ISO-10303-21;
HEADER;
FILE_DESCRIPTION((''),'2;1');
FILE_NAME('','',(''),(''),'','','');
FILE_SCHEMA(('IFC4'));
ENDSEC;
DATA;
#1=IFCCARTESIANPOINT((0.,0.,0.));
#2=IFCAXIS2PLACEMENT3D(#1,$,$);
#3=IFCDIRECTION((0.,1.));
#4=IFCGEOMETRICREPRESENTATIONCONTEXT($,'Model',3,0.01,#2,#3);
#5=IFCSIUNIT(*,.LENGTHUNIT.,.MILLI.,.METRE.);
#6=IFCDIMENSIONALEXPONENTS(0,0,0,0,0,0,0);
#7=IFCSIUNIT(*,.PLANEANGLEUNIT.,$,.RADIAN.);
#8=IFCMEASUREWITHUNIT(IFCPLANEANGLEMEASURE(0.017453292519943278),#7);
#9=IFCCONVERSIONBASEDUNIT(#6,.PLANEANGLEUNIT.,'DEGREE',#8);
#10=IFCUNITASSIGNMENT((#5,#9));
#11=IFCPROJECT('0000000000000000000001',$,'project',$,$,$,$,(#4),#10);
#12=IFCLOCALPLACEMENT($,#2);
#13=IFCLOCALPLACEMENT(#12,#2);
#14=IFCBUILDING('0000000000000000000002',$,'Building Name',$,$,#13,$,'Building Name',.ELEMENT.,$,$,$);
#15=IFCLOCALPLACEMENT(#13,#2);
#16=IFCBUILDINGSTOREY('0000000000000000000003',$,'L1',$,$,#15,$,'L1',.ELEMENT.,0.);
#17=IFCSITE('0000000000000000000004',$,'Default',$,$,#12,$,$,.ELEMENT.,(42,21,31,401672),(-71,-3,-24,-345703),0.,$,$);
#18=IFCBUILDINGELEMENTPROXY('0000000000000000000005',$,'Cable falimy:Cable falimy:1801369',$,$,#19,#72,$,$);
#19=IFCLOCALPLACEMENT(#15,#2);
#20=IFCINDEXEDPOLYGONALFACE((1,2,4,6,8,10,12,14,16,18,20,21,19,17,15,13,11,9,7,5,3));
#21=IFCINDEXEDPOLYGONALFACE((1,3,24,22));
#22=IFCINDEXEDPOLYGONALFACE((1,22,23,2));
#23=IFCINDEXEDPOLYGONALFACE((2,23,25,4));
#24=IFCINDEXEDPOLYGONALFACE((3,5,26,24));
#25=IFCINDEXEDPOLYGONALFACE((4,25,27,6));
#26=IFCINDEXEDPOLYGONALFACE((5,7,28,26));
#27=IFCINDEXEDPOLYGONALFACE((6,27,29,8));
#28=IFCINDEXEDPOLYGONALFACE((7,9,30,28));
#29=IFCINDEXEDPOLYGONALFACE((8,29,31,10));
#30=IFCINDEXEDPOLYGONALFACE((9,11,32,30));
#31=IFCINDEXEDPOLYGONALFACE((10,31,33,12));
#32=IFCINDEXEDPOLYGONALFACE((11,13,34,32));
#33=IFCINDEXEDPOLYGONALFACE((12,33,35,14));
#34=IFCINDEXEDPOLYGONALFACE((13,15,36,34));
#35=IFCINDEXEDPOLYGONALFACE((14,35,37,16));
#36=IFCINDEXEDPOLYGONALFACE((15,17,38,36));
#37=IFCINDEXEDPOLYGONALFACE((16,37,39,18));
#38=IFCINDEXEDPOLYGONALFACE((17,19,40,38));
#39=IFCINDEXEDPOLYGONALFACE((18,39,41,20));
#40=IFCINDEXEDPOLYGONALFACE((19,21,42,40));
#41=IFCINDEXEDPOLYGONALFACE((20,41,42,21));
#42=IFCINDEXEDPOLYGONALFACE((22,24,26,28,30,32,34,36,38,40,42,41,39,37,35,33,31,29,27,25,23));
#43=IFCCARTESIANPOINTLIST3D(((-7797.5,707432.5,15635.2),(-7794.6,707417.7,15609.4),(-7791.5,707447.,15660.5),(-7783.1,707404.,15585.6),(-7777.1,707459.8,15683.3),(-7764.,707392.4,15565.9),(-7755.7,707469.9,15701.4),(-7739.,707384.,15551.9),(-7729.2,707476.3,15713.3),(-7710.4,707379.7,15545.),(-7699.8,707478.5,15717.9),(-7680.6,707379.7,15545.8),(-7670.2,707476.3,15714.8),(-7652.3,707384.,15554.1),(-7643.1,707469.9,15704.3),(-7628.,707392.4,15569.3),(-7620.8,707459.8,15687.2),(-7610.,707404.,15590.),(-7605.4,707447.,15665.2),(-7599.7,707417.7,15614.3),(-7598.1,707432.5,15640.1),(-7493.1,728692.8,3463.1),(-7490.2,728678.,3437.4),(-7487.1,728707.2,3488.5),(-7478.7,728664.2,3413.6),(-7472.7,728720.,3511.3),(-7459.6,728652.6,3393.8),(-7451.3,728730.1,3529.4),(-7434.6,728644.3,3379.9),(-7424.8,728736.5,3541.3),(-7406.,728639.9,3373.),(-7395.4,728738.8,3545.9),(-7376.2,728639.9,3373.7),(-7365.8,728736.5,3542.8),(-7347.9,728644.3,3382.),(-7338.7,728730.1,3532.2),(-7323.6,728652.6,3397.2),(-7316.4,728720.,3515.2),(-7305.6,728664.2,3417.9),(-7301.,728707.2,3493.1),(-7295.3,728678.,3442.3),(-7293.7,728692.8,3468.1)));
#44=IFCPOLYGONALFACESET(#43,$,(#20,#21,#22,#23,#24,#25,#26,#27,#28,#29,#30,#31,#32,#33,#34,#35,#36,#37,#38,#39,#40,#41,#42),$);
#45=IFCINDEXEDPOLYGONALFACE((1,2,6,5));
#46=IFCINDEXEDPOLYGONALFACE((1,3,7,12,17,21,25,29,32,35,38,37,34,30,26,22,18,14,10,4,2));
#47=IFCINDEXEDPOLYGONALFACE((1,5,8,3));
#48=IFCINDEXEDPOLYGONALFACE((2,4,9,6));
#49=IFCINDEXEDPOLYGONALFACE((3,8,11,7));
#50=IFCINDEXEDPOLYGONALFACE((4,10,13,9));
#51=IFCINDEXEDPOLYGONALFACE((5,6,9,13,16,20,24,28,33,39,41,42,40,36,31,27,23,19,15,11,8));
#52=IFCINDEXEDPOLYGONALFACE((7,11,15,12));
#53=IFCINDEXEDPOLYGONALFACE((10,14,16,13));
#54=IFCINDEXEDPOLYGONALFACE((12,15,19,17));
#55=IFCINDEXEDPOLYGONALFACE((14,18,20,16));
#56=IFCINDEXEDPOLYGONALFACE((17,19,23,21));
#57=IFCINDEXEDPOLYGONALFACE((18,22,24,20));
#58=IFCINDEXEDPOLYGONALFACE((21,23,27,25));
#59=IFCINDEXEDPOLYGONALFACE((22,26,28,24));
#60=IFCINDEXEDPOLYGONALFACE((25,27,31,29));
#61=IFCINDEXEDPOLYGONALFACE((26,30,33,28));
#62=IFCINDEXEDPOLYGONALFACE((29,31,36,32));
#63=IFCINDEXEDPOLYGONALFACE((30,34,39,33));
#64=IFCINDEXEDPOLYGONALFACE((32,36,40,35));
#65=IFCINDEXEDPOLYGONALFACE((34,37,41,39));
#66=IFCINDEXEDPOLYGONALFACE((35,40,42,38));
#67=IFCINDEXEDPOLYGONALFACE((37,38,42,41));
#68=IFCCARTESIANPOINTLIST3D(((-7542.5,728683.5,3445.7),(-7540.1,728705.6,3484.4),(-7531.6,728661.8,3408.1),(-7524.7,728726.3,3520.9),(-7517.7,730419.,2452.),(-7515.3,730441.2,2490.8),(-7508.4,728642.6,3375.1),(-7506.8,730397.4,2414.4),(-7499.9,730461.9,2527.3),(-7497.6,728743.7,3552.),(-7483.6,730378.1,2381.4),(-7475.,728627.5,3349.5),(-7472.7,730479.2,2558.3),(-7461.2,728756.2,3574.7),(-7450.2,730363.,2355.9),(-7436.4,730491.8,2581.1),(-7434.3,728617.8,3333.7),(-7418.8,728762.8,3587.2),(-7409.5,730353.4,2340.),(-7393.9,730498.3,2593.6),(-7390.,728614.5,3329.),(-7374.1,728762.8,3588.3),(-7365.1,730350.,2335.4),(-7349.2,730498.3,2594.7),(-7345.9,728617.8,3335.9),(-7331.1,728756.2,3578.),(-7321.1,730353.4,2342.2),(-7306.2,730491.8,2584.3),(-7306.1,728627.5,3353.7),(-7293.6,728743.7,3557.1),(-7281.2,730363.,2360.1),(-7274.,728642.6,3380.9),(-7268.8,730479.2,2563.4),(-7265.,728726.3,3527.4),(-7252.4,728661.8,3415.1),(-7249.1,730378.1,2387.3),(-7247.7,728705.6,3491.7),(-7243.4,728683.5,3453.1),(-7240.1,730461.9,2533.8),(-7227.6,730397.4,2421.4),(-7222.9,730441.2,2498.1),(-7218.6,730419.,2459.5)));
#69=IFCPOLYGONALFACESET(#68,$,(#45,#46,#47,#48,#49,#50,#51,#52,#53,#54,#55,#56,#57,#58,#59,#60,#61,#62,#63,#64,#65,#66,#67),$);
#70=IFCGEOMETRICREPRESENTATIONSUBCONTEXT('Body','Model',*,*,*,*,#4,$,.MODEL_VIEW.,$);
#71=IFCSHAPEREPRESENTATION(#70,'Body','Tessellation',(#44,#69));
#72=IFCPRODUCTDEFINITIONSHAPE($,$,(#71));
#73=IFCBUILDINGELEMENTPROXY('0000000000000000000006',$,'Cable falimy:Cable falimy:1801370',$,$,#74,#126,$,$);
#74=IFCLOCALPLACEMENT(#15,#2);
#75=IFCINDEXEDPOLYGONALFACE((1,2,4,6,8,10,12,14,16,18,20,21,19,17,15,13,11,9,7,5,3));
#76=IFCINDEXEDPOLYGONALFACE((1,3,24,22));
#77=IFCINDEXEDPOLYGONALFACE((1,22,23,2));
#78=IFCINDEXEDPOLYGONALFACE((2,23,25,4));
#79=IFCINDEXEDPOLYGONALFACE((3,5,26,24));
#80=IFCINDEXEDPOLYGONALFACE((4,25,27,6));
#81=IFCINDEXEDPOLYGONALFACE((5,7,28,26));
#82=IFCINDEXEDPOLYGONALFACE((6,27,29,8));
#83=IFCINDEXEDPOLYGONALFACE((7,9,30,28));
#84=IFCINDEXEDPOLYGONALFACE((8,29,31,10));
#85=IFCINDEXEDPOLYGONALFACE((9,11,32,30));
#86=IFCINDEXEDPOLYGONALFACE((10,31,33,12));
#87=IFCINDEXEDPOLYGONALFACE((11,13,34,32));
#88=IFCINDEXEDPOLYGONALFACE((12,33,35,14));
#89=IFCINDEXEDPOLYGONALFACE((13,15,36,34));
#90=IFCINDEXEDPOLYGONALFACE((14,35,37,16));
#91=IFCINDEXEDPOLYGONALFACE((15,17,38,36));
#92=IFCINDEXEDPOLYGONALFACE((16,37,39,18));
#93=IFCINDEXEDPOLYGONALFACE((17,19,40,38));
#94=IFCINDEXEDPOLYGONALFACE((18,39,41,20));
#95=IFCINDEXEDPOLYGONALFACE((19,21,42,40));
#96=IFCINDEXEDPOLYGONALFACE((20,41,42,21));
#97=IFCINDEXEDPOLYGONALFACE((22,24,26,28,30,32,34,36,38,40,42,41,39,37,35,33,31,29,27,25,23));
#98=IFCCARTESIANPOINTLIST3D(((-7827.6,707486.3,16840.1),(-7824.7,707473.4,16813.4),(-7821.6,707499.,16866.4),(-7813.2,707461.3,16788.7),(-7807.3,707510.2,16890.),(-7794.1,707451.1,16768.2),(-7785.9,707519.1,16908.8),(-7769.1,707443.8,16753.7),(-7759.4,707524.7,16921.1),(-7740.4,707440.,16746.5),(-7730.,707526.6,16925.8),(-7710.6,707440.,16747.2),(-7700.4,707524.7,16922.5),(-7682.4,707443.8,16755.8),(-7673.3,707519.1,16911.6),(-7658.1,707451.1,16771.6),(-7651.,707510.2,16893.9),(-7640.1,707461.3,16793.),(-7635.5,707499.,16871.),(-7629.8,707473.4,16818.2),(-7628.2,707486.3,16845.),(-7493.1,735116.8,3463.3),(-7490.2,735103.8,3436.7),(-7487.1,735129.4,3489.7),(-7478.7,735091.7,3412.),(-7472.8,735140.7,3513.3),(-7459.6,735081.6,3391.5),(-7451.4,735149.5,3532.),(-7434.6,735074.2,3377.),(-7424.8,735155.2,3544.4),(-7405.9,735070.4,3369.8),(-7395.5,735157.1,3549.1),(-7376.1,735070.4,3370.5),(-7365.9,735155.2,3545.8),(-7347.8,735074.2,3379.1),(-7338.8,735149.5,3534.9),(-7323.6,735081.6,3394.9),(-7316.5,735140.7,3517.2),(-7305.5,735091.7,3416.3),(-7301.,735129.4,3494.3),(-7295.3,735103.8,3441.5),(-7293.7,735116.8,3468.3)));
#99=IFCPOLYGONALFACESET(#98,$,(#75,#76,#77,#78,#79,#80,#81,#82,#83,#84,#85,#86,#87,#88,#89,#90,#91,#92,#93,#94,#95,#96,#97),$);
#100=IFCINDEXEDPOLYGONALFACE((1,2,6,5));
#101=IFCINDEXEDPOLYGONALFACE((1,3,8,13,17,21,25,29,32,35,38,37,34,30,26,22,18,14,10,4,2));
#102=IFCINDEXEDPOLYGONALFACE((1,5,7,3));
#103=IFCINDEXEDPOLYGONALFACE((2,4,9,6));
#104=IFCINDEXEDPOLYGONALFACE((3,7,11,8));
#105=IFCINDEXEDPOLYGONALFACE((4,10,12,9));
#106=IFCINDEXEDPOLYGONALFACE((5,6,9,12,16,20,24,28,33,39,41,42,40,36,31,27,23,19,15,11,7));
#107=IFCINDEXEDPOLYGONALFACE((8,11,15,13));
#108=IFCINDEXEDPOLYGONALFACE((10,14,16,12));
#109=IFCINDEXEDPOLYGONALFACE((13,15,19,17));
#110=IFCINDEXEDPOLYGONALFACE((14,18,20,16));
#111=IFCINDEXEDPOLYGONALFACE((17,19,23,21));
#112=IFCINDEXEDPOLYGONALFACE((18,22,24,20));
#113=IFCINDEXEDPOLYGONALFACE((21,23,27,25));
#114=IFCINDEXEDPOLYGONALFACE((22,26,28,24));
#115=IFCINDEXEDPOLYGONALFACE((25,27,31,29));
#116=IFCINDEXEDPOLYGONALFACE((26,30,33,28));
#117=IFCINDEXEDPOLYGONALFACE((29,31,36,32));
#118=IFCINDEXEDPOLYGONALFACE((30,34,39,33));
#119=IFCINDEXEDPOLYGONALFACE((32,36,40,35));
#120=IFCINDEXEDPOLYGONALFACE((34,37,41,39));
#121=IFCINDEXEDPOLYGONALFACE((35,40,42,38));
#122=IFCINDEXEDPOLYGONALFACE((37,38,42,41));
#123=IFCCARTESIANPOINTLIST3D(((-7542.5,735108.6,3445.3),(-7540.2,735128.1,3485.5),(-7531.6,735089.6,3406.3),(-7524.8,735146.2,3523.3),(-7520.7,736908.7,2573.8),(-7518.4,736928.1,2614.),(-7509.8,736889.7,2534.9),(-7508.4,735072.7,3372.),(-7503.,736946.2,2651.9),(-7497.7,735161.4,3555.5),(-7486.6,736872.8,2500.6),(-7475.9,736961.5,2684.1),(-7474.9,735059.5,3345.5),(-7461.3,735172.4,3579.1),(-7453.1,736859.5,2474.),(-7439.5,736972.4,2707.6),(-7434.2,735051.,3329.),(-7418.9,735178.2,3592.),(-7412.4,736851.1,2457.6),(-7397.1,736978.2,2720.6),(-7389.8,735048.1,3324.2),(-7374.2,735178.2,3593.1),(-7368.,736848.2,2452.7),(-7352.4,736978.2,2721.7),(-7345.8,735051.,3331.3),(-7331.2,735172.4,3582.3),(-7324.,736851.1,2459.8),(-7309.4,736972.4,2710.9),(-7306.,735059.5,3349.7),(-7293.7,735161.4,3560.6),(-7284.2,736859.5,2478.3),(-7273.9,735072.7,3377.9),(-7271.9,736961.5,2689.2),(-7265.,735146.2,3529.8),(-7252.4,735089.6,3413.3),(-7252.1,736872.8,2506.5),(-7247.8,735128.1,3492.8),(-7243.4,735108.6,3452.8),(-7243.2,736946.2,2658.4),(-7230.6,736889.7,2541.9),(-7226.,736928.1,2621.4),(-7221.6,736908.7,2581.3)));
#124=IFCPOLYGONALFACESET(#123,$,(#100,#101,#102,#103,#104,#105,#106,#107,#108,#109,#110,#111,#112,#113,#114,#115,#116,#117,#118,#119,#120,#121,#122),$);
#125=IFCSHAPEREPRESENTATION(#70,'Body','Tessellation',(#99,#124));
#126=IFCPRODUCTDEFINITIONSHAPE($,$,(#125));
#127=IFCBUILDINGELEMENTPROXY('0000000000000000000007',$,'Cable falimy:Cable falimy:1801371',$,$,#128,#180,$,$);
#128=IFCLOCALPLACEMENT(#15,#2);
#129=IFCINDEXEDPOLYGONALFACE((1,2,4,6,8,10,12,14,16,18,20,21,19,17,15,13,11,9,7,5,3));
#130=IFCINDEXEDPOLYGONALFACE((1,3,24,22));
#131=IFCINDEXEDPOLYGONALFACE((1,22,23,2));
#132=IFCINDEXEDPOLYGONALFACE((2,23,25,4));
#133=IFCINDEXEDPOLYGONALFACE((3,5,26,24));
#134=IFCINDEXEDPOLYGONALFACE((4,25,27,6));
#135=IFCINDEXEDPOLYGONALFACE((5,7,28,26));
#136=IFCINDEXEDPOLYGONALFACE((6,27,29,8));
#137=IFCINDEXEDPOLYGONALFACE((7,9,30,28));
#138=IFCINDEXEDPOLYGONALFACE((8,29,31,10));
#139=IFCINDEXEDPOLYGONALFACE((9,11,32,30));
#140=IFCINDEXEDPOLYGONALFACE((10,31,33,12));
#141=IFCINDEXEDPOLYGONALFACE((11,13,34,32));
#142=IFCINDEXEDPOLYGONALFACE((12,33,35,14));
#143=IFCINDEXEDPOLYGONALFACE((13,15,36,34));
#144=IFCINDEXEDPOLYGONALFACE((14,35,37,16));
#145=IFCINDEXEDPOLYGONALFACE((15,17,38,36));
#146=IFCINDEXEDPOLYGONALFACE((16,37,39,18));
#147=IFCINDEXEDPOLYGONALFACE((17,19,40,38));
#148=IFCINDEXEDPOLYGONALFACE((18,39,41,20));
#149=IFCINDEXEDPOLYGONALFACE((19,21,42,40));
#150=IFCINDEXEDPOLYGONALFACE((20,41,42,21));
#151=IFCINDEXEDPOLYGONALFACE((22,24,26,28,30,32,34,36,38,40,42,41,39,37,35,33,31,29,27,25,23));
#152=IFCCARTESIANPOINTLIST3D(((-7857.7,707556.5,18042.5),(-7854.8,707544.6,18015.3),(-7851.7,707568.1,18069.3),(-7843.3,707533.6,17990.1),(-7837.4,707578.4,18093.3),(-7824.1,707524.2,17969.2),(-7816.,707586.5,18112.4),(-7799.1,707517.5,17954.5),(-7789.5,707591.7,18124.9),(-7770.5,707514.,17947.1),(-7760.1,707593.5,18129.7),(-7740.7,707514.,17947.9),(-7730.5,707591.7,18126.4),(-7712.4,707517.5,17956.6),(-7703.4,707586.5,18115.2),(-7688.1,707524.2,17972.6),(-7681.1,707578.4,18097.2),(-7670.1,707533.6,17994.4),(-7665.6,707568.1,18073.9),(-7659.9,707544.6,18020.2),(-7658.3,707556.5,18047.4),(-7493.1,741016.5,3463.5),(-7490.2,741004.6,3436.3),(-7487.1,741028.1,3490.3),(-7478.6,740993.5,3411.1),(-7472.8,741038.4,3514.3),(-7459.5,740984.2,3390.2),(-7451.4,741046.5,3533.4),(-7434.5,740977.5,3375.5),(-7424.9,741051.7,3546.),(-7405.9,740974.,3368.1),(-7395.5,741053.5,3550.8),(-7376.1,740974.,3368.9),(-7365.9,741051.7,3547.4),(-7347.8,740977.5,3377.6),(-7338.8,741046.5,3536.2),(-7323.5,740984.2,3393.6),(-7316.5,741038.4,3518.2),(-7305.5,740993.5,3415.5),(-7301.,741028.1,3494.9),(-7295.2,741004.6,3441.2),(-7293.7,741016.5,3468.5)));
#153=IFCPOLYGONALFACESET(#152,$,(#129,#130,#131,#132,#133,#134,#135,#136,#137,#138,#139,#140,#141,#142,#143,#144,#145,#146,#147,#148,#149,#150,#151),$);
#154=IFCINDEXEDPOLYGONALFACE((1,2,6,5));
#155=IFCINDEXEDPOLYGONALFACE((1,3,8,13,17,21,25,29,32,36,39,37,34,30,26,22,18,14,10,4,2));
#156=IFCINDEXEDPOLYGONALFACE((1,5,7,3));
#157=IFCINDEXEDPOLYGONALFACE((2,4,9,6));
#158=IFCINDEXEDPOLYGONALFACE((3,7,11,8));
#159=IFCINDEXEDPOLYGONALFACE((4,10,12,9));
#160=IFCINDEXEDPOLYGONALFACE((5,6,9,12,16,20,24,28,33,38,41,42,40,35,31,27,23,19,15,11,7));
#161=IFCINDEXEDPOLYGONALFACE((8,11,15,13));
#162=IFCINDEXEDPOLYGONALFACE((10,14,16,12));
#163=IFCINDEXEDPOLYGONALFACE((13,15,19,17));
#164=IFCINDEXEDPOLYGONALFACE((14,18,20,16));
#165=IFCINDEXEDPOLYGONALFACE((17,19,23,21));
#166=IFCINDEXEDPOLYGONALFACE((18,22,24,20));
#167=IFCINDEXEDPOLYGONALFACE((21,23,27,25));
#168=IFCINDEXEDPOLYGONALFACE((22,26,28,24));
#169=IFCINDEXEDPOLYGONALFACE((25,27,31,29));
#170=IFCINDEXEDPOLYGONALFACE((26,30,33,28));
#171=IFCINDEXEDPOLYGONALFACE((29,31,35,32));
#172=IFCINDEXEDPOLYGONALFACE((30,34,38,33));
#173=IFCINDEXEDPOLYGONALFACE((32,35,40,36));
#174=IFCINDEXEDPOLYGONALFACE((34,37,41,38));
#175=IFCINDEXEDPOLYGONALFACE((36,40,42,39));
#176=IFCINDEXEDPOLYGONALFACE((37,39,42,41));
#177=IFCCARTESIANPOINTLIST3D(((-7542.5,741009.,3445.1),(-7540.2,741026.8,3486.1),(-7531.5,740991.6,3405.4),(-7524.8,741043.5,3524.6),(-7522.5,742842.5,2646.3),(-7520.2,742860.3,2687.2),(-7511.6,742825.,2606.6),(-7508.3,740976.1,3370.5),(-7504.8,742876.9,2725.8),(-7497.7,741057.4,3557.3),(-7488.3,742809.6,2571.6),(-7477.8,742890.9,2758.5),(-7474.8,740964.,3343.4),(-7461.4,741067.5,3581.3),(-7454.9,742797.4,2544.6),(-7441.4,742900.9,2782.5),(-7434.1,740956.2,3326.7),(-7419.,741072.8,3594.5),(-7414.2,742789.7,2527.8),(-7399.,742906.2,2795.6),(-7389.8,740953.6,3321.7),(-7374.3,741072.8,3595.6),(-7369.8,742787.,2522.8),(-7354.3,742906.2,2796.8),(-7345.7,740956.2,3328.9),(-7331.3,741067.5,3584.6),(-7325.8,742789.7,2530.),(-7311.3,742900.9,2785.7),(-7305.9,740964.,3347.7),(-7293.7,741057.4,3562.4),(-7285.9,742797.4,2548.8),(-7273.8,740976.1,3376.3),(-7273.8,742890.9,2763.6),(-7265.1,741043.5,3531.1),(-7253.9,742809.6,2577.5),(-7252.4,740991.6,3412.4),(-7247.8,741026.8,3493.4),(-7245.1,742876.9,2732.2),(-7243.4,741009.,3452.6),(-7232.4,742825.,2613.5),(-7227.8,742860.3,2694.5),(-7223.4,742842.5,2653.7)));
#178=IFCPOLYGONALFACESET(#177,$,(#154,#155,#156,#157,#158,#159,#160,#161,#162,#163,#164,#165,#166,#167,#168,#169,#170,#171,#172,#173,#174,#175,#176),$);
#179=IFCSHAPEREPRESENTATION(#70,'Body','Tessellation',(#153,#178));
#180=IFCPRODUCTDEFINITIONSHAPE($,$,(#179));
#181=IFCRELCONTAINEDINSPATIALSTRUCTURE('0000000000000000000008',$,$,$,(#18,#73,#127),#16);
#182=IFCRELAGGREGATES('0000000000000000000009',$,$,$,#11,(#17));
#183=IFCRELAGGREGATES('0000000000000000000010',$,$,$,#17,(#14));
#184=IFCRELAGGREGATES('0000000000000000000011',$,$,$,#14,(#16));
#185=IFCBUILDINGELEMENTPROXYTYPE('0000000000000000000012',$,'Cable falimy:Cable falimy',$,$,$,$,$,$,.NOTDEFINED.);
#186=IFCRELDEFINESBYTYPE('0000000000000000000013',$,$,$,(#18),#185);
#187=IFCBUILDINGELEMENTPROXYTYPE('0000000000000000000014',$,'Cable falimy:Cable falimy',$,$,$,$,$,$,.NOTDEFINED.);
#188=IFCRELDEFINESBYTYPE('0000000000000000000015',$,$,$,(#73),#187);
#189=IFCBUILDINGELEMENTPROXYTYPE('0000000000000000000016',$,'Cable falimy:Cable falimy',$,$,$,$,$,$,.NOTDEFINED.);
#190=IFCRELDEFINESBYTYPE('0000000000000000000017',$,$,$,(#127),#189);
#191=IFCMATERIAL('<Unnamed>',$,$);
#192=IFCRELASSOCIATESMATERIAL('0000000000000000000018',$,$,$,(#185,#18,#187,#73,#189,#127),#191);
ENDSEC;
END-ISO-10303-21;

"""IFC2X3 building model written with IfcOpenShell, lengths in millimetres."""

from ifc_helpers import new_model, entity, si_unit, converted_unit, direction, frame, frame_2d, origin, place, context, subcontext, project, spatial, circle, extrude, source, transform, mapped, material, type_object, type_shapes, element, save


model = new_model("IFC2X3")

# Units and contexts
model_context = context("Model", 3, precision=0.01, world=origin(), true_north=direction((0.0, 1.0)))
body_context = subcontext(model_context, "Body", "Model", "MODEL_VIEW")
ifc_project = project(units=[si_unit("LENGTHUNIT", "METRE", prefix="MILLI"), converted_unit("PLANEANGLEUNIT", "DEGREE", entity("IfcPlaneAngleMeasure", 0.017453292519943278), si_unit("PLANEANGLEUNIT", "RADIAN"), dimensions=[0, 0, 0, 0, 0, 0, 0])], contexts=[model_context])

# Site, building, storey
site_placement = place(None, origin())
site = spatial("IfcSite", under=ifc_project, at=site_placement, Name="Default", CompositionType="ELEMENT", RefLatitude=(42, 21, 31, 401672), RefLongitude=(-71, -3, -24, -345703), RefElevation=0.0)
building_placement = place(site_placement, origin())
building = spatial("IfcBuilding", under=site, at=building_placement, Name="Building Name", LongName="Building Name", CompositionType="ELEMENT")
storey_placement = place(building_placement, origin())
storey = spatial("IfcBuildingStorey", under=building, at=storey_placement, Name="L1", LongName="L1", CompositionType="ELEMENT", Elevation=0.0)

# Shared definitions
ifc_material = material(Name="<Unnamed>")

# Building element proxies
building_element_proxy_type_1 = type_object("IfcBuildingElementProxyType", Name="Cable falimy:Cable falimy", PredefinedType="NOTDEFINED", material=ifc_material)
shared_shape_1 = source(origin(), body_context, "Body", "SweptSolid", [
    extrude(circle(Radius=100.0, at=frame_2d((0.0, 0.0), x_axis=(1.0, 0.0))), frame((0.0, 0.0, 0.0), z_axis=(0.867765, 0.0, 0.496974), x_axis=(-0.496974, 0.0, 0.867765)), (0.0, 0.0, 1.0), 24500.0),
    extrude(circle(Radius=150.0, at=frame_2d((0.0, 0.0), x_axis=(1.0, 0.0))), frame((-1735.5, 0.0, -993.9), z_axis=(0.867765, 0.0, 0.496974), x_axis=(0.496974, 0.0, -0.867765)), (0.0, 0.0, 1.0), 2000.0),
])
type_shapes(building_element_proxy_type_1, [shared_shape_1])
proxy_1_placement = place(storey_placement, frame((-7393.2, 728689.1, 3459.1), z_axis=(-0.025001, 0.0, 0.999687), x_axis=(0.0, -1.0, 0.0)))
element("IfcBuildingElementProxy", 1, at=proxy_1_placement, inside=storey, type_object=building_element_proxy_type_1, material=ifc_material, Name="Cable falimy:Cable falimy:1801369", context=body_context, shape_type="MappedRepresentation", body=[
    mapped(shared_shape_1, transform((0.0, 0.0, 0.0), scale=1.0)),
])
building_element_proxy_type_2 = type_object("IfcBuildingElementProxyType", Name="Cable falimy:Cable falimy", PredefinedType="NOTDEFINED", material=ifc_material)
shared_shape_2 = source(origin(), body_context, "Body", "SweptSolid", [
    extrude(circle(Radius=100.0, at=frame_2d((0.0, 0.0), x_axis=(1.0, 0.0))), frame((0.0, 0.0, 0.0), z_axis=(0.900015, 0.0, 0.43586), x_axis=(-0.43586, 0.0, 0.900015)), (0.0, 0.0, 1.0), 30700.0),
    extrude(circle(Radius=150.0, at=frame_2d((0.0, 0.0), x_axis=(1.0, 0.0))), frame((-1800.0, 0.0, -871.7), z_axis=(0.900015, 0.0, 0.43586), x_axis=(0.43586, 0.0, -0.900015)), (0.0, 0.0, 1.0), 2000.0),
])
type_shapes(building_element_proxy_type_2, [shared_shape_2])
proxy_2_placement = place(storey_placement, frame((-7393.2, 735113.5, 3459.1), z_axis=(-0.025001, 0.0, 0.999687), x_axis=(0.0, -1.0, 0.0)))
element("IfcBuildingElementProxy", 2, at=proxy_2_placement, inside=storey, type_object=building_element_proxy_type_2, material=ifc_material, Name="Cable falimy:Cable falimy:1801370", context=body_context, shape_type="MappedRepresentation", body=[
    mapped(shared_shape_2, transform((0.0, 0.0, 0.0), scale=1.0)),
])
building_element_proxy_type_3 = type_object("IfcBuildingElementProxyType", Name="Cable falimy:Cable falimy", PredefinedType="NOTDEFINED", material=ifc_material)
shared_shape_3 = source(origin(), body_context, "Body", "SweptSolid", [
    extrude(circle(Radius=100.0, at=frame_2d((0.0, 0.0), x_axis=(1.0, 0.0))), frame((0.0, 0.0, 0.0), z_axis=(0.916712, 0.0, 0.399549), x_axis=(-0.399549, 0.0, 0.916712)), (0.0, 0.0, 1.0), 36500.0),
    extrude(circle(Radius=150.0, at=frame_2d((0.0, 0.0), x_axis=(1.0, 0.0))), frame((-1833.4, 0.0, -799.1), z_axis=(0.916712, 0.0, 0.399549), x_axis=(0.399549, 0.0, -0.916712)), (0.0, 0.0, 1.0), 2000.0),
])
type_shapes(building_element_proxy_type_3, [shared_shape_3])
proxy_3_placement = place(storey_placement, frame((-7393.2, 741013.5, 3459.1), z_axis=(-0.025001, 0.0, 0.999687), x_axis=(0.0, -1.0, 0.0)))
element("IfcBuildingElementProxy", 3, at=proxy_3_placement, inside=storey, type_object=building_element_proxy_type_3, material=ifc_material, Name="Cable falimy:Cable falimy:1801371", context=body_context, shape_type="MappedRepresentation", body=[
    mapped(shared_shape_3, transform((0.0, 0.0, 0.0), scale=1.0)),
])

save(model, "model.ifc")
